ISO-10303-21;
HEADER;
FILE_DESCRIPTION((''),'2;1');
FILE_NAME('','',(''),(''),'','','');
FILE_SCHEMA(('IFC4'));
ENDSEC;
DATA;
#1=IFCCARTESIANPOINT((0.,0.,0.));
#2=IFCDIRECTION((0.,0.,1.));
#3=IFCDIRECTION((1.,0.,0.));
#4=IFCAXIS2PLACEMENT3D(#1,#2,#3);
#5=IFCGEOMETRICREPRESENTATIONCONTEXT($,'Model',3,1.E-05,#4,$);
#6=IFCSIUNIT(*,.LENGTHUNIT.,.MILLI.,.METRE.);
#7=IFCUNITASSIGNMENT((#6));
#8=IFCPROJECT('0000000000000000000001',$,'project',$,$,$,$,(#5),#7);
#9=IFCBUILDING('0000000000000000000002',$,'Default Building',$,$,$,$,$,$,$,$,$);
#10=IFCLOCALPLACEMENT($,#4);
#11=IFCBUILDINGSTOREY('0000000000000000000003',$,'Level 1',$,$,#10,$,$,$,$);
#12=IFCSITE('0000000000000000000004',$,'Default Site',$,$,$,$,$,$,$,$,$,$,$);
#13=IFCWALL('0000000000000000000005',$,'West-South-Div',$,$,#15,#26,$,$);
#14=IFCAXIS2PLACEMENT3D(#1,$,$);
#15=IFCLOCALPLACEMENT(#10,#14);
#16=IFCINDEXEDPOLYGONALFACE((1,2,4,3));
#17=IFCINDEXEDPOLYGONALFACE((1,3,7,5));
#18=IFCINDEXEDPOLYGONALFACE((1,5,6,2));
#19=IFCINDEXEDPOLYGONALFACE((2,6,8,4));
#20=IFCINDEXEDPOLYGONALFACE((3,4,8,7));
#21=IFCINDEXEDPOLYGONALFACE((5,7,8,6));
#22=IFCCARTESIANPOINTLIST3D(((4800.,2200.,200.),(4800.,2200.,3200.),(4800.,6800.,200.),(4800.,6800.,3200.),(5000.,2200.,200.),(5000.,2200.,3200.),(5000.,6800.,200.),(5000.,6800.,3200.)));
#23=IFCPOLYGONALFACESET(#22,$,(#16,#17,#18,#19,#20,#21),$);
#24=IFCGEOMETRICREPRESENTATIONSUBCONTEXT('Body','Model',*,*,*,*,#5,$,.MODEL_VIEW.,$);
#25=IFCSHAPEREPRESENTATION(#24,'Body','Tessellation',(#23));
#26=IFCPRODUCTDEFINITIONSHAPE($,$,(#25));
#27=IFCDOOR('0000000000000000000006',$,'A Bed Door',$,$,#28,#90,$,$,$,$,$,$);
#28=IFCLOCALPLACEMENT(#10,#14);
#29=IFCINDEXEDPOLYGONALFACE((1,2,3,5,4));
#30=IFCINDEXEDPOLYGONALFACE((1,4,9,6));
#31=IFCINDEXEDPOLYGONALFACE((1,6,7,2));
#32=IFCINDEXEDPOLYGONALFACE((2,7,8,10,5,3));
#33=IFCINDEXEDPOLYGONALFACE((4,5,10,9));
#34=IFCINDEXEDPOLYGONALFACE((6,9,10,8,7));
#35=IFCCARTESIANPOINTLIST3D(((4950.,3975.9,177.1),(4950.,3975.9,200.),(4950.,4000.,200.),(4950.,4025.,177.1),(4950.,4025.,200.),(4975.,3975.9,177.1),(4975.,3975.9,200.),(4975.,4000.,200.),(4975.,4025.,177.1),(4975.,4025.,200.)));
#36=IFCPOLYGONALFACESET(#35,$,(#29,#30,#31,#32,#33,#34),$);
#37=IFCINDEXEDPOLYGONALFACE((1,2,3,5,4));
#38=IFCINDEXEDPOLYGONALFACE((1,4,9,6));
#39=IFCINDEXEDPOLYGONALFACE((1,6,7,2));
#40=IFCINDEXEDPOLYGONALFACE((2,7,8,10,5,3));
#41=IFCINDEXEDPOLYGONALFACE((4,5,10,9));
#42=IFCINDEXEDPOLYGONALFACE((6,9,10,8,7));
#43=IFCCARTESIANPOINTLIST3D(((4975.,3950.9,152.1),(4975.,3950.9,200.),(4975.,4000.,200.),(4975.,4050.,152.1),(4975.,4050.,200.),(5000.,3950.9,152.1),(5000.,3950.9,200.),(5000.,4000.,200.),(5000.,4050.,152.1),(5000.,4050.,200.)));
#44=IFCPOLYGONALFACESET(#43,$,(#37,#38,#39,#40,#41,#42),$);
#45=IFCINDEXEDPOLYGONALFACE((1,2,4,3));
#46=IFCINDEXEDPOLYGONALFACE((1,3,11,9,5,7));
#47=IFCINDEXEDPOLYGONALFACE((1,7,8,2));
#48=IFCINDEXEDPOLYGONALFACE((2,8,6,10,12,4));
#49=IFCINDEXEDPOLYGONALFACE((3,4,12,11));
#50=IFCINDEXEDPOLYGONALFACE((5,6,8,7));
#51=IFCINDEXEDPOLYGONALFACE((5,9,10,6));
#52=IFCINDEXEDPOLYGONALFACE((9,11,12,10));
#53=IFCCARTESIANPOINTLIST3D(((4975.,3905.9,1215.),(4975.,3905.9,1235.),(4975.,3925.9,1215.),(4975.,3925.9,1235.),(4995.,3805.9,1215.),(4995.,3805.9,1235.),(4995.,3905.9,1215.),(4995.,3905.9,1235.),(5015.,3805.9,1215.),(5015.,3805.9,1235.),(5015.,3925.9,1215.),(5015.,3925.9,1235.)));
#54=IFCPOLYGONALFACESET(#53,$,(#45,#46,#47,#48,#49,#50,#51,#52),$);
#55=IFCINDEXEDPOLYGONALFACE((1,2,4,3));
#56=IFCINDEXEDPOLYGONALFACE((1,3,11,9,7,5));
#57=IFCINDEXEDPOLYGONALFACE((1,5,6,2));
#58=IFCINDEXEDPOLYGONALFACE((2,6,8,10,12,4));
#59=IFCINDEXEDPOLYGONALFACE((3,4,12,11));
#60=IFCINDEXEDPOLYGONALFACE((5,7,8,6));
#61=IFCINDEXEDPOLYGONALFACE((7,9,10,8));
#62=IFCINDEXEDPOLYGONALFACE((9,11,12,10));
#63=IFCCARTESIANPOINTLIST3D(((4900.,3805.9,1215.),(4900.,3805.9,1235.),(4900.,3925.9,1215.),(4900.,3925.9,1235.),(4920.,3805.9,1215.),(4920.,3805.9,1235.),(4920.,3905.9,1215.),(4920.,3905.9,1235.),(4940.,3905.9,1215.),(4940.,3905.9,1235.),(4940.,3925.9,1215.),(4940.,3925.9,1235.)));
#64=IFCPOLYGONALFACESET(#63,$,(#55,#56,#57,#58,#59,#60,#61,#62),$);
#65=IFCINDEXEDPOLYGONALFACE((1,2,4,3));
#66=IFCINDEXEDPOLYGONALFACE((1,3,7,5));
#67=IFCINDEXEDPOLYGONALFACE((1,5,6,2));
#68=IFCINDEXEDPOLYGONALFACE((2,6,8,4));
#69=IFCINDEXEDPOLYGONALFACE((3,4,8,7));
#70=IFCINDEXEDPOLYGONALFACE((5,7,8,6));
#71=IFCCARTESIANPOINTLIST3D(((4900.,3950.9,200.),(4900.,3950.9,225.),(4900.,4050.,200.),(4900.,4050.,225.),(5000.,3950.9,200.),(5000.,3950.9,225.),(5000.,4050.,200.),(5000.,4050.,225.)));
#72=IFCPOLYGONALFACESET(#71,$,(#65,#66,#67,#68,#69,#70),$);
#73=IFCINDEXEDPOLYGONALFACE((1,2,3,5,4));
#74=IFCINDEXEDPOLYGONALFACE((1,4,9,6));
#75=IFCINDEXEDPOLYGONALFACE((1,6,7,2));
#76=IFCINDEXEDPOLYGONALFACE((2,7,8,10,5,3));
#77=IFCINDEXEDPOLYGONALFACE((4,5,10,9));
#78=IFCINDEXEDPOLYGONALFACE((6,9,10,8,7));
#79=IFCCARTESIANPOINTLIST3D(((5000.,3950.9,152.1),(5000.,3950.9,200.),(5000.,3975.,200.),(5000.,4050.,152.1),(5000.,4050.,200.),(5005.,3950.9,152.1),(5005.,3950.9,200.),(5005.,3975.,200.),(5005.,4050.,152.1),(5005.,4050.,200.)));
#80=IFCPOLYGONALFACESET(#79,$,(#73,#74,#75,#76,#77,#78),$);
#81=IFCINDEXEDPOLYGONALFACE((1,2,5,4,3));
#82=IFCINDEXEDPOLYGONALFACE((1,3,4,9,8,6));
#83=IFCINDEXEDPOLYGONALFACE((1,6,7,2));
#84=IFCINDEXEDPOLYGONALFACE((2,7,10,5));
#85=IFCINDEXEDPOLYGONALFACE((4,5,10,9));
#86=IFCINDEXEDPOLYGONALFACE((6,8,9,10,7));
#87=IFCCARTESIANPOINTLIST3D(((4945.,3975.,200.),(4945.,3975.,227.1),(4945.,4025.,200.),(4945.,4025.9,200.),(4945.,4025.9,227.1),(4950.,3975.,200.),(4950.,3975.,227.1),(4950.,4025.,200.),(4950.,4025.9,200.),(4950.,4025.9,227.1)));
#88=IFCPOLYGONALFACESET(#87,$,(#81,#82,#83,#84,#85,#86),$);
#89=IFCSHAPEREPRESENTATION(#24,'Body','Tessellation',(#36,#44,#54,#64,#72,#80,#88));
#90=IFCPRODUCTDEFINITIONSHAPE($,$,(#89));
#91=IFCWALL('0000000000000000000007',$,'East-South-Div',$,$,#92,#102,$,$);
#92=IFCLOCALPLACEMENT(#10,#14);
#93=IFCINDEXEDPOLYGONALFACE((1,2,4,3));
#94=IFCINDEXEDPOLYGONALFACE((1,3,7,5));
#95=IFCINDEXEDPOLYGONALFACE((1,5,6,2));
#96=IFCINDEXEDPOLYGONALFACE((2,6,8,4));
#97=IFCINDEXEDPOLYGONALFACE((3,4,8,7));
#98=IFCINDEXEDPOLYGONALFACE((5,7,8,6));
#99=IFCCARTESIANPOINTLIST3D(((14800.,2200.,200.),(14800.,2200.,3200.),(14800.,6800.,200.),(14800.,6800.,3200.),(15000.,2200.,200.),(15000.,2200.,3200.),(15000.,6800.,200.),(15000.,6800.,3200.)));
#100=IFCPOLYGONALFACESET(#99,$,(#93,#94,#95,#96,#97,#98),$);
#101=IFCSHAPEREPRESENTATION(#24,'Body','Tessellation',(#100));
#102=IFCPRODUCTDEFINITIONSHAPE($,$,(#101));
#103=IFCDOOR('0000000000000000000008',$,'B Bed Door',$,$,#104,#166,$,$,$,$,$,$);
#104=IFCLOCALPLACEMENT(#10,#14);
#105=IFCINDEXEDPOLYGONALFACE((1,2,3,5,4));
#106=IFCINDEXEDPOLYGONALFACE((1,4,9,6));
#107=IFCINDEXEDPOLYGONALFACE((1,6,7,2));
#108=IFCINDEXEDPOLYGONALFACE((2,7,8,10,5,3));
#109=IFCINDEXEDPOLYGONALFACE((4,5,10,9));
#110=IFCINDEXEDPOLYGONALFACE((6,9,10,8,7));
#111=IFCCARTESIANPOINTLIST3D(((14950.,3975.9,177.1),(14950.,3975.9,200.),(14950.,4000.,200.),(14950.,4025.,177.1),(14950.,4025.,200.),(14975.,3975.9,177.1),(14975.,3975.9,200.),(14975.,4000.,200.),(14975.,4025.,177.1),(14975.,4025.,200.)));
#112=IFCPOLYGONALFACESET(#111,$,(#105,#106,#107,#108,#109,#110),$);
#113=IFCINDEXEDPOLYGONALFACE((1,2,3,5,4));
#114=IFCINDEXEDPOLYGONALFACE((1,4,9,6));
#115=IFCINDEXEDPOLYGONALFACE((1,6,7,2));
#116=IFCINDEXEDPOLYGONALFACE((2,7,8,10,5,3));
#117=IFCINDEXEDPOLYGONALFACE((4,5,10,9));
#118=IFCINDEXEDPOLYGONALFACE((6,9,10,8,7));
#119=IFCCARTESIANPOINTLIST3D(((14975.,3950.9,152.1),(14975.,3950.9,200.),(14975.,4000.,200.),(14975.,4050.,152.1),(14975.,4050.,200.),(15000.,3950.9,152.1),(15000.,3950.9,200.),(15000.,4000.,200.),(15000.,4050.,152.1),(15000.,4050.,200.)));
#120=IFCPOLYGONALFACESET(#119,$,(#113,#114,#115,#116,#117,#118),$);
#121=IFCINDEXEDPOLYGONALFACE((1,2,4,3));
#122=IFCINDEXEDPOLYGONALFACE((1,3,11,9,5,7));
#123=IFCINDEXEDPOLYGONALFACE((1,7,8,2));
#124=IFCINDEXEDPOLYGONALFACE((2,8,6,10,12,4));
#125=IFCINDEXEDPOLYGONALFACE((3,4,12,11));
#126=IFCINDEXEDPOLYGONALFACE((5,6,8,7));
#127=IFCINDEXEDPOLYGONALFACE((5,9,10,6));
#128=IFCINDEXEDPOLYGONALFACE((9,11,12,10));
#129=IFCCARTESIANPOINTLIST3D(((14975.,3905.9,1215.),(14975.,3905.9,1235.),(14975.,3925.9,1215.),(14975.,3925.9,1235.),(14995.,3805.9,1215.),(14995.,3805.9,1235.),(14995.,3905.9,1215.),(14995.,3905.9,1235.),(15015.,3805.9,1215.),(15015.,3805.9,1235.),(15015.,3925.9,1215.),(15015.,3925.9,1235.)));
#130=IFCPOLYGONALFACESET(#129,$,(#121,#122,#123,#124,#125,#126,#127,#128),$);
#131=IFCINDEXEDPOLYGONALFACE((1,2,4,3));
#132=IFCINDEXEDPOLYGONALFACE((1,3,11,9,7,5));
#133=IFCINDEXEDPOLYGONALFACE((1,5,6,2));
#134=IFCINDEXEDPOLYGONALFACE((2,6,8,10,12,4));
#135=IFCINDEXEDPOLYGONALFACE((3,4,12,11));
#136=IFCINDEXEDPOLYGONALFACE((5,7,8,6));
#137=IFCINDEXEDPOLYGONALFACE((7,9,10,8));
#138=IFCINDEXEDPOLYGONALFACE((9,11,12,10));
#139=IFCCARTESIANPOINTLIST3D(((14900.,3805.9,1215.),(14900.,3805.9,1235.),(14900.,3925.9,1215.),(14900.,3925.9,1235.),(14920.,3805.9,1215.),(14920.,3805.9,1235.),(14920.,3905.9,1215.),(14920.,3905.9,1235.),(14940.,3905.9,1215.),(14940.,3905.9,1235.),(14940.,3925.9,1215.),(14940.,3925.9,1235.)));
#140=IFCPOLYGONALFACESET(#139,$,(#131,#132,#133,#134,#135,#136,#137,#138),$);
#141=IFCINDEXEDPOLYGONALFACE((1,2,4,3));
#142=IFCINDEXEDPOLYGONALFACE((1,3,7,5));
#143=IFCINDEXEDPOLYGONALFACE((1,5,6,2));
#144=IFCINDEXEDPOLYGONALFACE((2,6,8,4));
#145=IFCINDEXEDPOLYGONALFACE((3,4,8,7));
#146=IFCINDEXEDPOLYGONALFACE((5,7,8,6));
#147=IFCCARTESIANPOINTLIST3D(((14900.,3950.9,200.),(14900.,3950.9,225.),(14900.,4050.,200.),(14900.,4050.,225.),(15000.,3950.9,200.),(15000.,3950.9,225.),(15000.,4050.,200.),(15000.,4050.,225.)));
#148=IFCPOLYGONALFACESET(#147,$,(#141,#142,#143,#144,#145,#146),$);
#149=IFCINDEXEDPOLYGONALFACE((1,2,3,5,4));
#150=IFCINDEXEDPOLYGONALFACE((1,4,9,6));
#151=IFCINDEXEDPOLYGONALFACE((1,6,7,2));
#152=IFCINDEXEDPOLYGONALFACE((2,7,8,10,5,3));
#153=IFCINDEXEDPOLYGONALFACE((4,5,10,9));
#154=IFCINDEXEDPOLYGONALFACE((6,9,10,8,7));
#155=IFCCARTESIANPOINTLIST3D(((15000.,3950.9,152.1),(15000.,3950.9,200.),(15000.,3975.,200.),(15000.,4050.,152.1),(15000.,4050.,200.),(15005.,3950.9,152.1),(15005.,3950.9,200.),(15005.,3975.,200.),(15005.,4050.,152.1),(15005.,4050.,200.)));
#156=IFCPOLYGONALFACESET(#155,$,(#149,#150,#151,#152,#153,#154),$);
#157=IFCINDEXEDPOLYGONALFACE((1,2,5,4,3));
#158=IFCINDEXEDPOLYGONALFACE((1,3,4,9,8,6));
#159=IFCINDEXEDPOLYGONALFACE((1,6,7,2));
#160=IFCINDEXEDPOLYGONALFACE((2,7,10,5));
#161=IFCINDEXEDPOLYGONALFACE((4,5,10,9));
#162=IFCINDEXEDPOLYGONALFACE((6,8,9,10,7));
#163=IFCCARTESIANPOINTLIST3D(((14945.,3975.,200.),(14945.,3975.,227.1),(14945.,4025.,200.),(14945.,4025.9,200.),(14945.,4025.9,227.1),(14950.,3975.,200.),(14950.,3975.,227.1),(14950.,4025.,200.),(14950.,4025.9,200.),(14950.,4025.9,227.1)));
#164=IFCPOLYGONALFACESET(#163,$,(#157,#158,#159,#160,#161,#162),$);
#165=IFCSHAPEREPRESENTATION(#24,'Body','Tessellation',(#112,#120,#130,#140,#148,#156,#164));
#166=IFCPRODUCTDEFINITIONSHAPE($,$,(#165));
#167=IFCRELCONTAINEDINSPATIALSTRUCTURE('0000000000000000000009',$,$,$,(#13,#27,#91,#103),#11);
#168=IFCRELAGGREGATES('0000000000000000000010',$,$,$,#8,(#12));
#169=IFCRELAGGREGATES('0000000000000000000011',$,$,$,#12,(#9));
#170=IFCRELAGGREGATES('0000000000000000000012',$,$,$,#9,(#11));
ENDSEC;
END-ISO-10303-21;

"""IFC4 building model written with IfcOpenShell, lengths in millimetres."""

from ifc_helpers import new_model, si_unit, frame, origin_with_axes, place, context, subcontext, project, spatial, line, indexed_curve, outline, extrude, element, fill, save


model = new_model("IFC4")

# Units and contexts
model_context = context("Model", 3, precision=1e-05, world=origin_with_axes())
body_context = subcontext(model_context, "Body", "Model", "MODEL_VIEW")
ifc_project = project(units=[si_unit("LENGTHUNIT", "METRE", prefix="MILLI")], contexts=[model_context])

# Site, building, storey
site = spatial("IfcSite", under=ifc_project, Name="Default Site")
building = spatial("IfcBuilding", under=site, Name="Default Building")
storey_placement = place(None, origin_with_axes())
storey = spatial("IfcBuildingStorey", under=building, at=storey_placement, Name="Level 1")

# Walls, openings, doors
wall_1_placement = place(storey_placement, frame((0.0, 0.0, 200.0), z_axis=(0.0, 0.0, 1.0), x_axis=(1.0, 0.0, 0.0)))
wall_1 = element("IfcWall", 1, at=wall_1_placement, inside=storey, Name="West-South-Div", context=body_context, shape_type="SweptSolid", body=[
    extrude(outline(indexed_curve([(5000.0, 2200.0), (5000.0, 6800.0), (4800.0, 6800.0), (4800.0, 2200.0), (5000.0, 2200.0)])), None, (0.0, 0.0, 1.0), 3000.0),
])
opening_1_placement = place(wall_1_placement, origin_with_axes())
opening_1 = element("IfcOpeningElement", 2, at=opening_1_placement, cuts=wall_1, context=body_context, shape_type="SweptSolid", body=[
    extrude(outline(indexed_curve([(5000.0, 4000.0), (5200.0, 4000.0), (5200.0, 4900.0), (5000.0, 4900.0), (5000.0, 4000.0)])), None, (0.0, 0.0, 1.0), 2100.0),
])
door_1_placement = place(storey_placement, frame((5000.0, 4000.0, 200.0), z_axis=(0.0, 0.0, 1.0), x_axis=(0.0, 1.0, 0.0)))
door_1 = element("IfcDoor", 3, at=door_1_placement, inside=storey, Name="A Bed Door", context=body_context, shape_type="SweptSolid", body=[
    extrude(outline(indexed_curve([(0.0, 0.0), (0.0, 2.1), (0.9, 2.1), (0.9, 0.0), (-24.1, 0.0), (-24.1, -22.9), (25.0, -22.9), (25.0, 0.0)], segments=[line(1, 2, 3, 4, 5, 6, 7, 8, 1)])), frame((0.0, 25.0, 0.0), z_axis=(0.0, -1.0, 0.0), x_axis=(1.0, 0.0, 0.0)), (0.0, 0.0, -1.0), 25.0),
    extrude(outline(indexed_curve([(0.0, 0.0), (0.0, 2.1), (0.9, 2.1), (0.9, 0.0), (-49.1, 0.0), (-49.1, -47.9), (50.0, -47.9), (50.0, 0.0)], segments=[line(1, 2, 3, 4, 5, 6, 7, 8, 1)])), frame((0.0, 0.0, 0.0), z_axis=(0.0, -1.0, 0.0), x_axis=(1.0, 0.0, 0.0)), (0.0, 0.0, -1.0), 25.0),
    extrude(outline(indexed_curve([(0.0, 0.0), (-49.1, 0.0), (-49.1, 35.0), (0.0, 35.0)], segments=[line(1, 2, 3, 4, 1)])), frame((25.0, 25.0, 25.0), z_axis=(0.0, 0.0, 1.0), x_axis=(1.0, 0.0, 0.0)), (0.0, 0.0, 1.0), -47.9),
    extrude(outline(indexed_curve([(0.0, 0.0), (0.0, -40.0), (-120.0, -40.0), (-120.0, -20.0), (-20.0, -20.0), (-20.0, 0.0)], segments=[line(1, 2, 3, 4, 5, 6, 1)])), frame((-74.1, 25.0, 1015.0), z_axis=(0.0, 0.0, 1.0), x_axis=(1.0, 0.0, 0.0)), (0.0, 0.0, 1.0), 20.0),
    extrude(outline(indexed_curve([(0.0, 0.0), (0.0, 40.0), (-120.0, 40.0), (-120.0, 20.0), (-20.0, 20.0), (-20.0, 0.0)], segments=[line(1, 2, 3, 4, 5, 6, 1)])), frame((-74.1, 60.0, 1015.0), z_axis=(0.0, 0.0, 1.0), x_axis=(1.0, 0.0, 0.0)), (0.0, 0.0, 1.0), 20.0),
    extrude(outline(indexed_curve([(0.0, 0.0), (-99.1, 0.0), (-99.1, 100.0), (0.0, 100.0)], segments=[line(1, 2, 3, 4, 1)])), frame((50.0, 0.0, 0.0), z_axis=(0.0, 0.0, 1.0), x_axis=(1.0, 0.0, 0.0)), (0.0, 0.0, 1.0), 25.0),
    extrude(outline(indexed_curve([(0.0, 0.0), (0.0, 27.1), (50.9, 27.1), (50.9, 0.0), (-24.1, 0.0), (-24.1, -47.9), (75.0, -47.9), (75.0, 0.0)], segments=[line(1, 2, 3, 4, 5, 6, 7, 8, 1)])), frame((-25.0, -5.0, 0.0), z_axis=(0.0, -1.0, 0.0), x_axis=(1.0, 0.0, 0.0)), (0.0, 0.0, -1.0), 5.0),
    extrude(outline(indexed_curve([(0.0, 0.0), (0.0, 27.1), (50.9, 27.1), (50.9, 0.0), (0.9, 0.0), (0.9, -22.9), (50.0, -22.9), (50.0, 0.0)], segments=[line(1, 2, 3, 4, 5, 6, 7, 8, 1)])), frame((-25.0, 50.0, 0.0), z_axis=(0.0, -1.0, 0.0), x_axis=(1.0, 0.0, 0.0)), (0.0, 0.0, -1.0), 5.0),
])
fill(opening_1, door_1)
wall_2_placement = place(storey_placement, frame((0.0, 0.0, 200.0), z_axis=(0.0, 0.0, 1.0), x_axis=(1.0, 0.0, 0.0)))
wall_2 = element("IfcWall", 4, at=wall_2_placement, inside=storey, Name="East-South-Div", context=body_context, shape_type="SweptSolid", body=[
    extrude(outline(indexed_curve([(15000.0, 2200.0), (15000.0, 6800.0), (14800.0, 6800.0), (14800.0, 2200.0), (15000.0, 2200.0)])), None, (0.0, 0.0, 1.0), 3000.0),
])
opening_2_placement = place(wall_2_placement, origin_with_axes())
opening_2 = element("IfcOpeningElement", 5, at=opening_2_placement, cuts=wall_2, context=body_context, shape_type="SweptSolid", body=[
    extrude(outline(indexed_curve([(15000.0, 4000.0), (15200.0, 4000.0), (15200.0, 4900.0), (15000.0, 4900.0), (15000.0, 4000.0)])), None, (0.0, 0.0, 1.0), 2100.0),
])
door_2_placement = place(storey_placement, frame((15000.0, 4000.0, 200.0), z_axis=(0.0, 0.0, 1.0), x_axis=(0.0, 1.0, 0.0)))
door_2 = element("IfcDoor", 6, at=door_2_placement, inside=storey, Name="B Bed Door", context=body_context, shape_type="SweptSolid", body=[
    extrude(outline(indexed_curve([(0.0, 0.0), (0.0, 2.1), (0.9, 2.1), (0.9, 0.0), (-24.1, 0.0), (-24.1, -22.9), (25.0, -22.9), (25.0, 0.0)], segments=[line(1, 2, 3, 4, 5, 6, 7, 8, 1)])), frame((0.0, 25.0, 0.0), z_axis=(0.0, -1.0, 0.0), x_axis=(1.0, 0.0, 0.0)), (0.0, 0.0, -1.0), 25.0),
    extrude(outline(indexed_curve([(0.0, 0.0), (0.0, 2.1), (0.9, 2.1), (0.9, 0.0), (-49.1, 0.0), (-49.1, -47.9), (50.0, -47.9), (50.0, 0.0)], segments=[line(1, 2, 3, 4, 5, 6, 7, 8, 1)])), frame((0.0, 0.0, 0.0), z_axis=(0.0, -1.0, 0.0), x_axis=(1.0, 0.0, 0.0)), (0.0, 0.0, -1.0), 25.0),
    extrude(outline(indexed_curve([(0.0, 0.0), (-49.1, 0.0), (-49.1, 35.0), (0.0, 35.0)], segments=[line(1, 2, 3, 4, 1)])), frame((25.0, 25.0, 25.0), z_axis=(0.0, 0.0, 1.0), x_axis=(1.0, 0.0, 0.0)), (0.0, 0.0, 1.0), -47.9),
    extrude(outline(indexed_curve([(0.0, 0.0), (0.0, -40.0), (-120.0, -40.0), (-120.0, -20.0), (-20.0, -20.0), (-20.0, 0.0)], segments=[line(1, 2, 3, 4, 5, 6, 1)])), frame((-74.1, 25.0, 1015.0), z_axis=(0.0, 0.0, 1.0), x_axis=(1.0, 0.0, 0.0)), (0.0, 0.0, 1.0), 20.0),
    extrude(outline(indexed_curve([(0.0, 0.0), (0.0, 40.0), (-120.0, 40.0), (-120.0, 20.0), (-20.0, 20.0), (-20.0, 0.0)], segments=[line(1, 2, 3, 4, 5, 6, 1)])), frame((-74.1, 60.0, 1015.0), z_axis=(0.0, 0.0, 1.0), x_axis=(1.0, 0.0, 0.0)), (0.0, 0.0, 1.0), 20.0),
    extrude(outline(indexed_curve([(0.0, 0.0), (-99.1, 0.0), (-99.1, 100.0), (0.0, 100.0)], segments=[line(1, 2, 3, 4, 1)])), frame((50.0, 0.0, 0.0), z_axis=(0.0, 0.0, 1.0), x_axis=(1.0, 0.0, 0.0)), (0.0, 0.0, 1.0), 25.0),
    extrude(outline(indexed_curve([(0.0, 0.0), (0.0, 27.1), (50.9, 27.1), (50.9, 0.0), (-24.1, 0.0), (-24.1, -47.9), (75.0, -47.9), (75.0, 0.0)], segments=[line(1, 2, 3, 4, 5, 6, 7, 8, 1)])), frame((-25.0, -5.0, 0.0), z_axis=(0.0, -1.0, 0.0), x_axis=(1.0, 0.0, 0.0)), (0.0, 0.0, -1.0), 5.0),
    extrude(outline(indexed_curve([(0.0, 0.0), (0.0, 27.1), (50.9, 27.1), (50.9, 0.0), (0.9, 0.0), (0.9, -22.9), (50.0, -22.9), (50.0, 0.0)], segments=[line(1, 2, 3, 4, 5, 6, 7, 8, 1)])), frame((-25.0, 50.0, 0.0), z_axis=(0.0, -1.0, 0.0), x_axis=(1.0, 0.0, 0.0)), (0.0, 0.0, -1.0), 5.0),
])
fill(opening_2, door_2)

save(model, "model.ifc")
